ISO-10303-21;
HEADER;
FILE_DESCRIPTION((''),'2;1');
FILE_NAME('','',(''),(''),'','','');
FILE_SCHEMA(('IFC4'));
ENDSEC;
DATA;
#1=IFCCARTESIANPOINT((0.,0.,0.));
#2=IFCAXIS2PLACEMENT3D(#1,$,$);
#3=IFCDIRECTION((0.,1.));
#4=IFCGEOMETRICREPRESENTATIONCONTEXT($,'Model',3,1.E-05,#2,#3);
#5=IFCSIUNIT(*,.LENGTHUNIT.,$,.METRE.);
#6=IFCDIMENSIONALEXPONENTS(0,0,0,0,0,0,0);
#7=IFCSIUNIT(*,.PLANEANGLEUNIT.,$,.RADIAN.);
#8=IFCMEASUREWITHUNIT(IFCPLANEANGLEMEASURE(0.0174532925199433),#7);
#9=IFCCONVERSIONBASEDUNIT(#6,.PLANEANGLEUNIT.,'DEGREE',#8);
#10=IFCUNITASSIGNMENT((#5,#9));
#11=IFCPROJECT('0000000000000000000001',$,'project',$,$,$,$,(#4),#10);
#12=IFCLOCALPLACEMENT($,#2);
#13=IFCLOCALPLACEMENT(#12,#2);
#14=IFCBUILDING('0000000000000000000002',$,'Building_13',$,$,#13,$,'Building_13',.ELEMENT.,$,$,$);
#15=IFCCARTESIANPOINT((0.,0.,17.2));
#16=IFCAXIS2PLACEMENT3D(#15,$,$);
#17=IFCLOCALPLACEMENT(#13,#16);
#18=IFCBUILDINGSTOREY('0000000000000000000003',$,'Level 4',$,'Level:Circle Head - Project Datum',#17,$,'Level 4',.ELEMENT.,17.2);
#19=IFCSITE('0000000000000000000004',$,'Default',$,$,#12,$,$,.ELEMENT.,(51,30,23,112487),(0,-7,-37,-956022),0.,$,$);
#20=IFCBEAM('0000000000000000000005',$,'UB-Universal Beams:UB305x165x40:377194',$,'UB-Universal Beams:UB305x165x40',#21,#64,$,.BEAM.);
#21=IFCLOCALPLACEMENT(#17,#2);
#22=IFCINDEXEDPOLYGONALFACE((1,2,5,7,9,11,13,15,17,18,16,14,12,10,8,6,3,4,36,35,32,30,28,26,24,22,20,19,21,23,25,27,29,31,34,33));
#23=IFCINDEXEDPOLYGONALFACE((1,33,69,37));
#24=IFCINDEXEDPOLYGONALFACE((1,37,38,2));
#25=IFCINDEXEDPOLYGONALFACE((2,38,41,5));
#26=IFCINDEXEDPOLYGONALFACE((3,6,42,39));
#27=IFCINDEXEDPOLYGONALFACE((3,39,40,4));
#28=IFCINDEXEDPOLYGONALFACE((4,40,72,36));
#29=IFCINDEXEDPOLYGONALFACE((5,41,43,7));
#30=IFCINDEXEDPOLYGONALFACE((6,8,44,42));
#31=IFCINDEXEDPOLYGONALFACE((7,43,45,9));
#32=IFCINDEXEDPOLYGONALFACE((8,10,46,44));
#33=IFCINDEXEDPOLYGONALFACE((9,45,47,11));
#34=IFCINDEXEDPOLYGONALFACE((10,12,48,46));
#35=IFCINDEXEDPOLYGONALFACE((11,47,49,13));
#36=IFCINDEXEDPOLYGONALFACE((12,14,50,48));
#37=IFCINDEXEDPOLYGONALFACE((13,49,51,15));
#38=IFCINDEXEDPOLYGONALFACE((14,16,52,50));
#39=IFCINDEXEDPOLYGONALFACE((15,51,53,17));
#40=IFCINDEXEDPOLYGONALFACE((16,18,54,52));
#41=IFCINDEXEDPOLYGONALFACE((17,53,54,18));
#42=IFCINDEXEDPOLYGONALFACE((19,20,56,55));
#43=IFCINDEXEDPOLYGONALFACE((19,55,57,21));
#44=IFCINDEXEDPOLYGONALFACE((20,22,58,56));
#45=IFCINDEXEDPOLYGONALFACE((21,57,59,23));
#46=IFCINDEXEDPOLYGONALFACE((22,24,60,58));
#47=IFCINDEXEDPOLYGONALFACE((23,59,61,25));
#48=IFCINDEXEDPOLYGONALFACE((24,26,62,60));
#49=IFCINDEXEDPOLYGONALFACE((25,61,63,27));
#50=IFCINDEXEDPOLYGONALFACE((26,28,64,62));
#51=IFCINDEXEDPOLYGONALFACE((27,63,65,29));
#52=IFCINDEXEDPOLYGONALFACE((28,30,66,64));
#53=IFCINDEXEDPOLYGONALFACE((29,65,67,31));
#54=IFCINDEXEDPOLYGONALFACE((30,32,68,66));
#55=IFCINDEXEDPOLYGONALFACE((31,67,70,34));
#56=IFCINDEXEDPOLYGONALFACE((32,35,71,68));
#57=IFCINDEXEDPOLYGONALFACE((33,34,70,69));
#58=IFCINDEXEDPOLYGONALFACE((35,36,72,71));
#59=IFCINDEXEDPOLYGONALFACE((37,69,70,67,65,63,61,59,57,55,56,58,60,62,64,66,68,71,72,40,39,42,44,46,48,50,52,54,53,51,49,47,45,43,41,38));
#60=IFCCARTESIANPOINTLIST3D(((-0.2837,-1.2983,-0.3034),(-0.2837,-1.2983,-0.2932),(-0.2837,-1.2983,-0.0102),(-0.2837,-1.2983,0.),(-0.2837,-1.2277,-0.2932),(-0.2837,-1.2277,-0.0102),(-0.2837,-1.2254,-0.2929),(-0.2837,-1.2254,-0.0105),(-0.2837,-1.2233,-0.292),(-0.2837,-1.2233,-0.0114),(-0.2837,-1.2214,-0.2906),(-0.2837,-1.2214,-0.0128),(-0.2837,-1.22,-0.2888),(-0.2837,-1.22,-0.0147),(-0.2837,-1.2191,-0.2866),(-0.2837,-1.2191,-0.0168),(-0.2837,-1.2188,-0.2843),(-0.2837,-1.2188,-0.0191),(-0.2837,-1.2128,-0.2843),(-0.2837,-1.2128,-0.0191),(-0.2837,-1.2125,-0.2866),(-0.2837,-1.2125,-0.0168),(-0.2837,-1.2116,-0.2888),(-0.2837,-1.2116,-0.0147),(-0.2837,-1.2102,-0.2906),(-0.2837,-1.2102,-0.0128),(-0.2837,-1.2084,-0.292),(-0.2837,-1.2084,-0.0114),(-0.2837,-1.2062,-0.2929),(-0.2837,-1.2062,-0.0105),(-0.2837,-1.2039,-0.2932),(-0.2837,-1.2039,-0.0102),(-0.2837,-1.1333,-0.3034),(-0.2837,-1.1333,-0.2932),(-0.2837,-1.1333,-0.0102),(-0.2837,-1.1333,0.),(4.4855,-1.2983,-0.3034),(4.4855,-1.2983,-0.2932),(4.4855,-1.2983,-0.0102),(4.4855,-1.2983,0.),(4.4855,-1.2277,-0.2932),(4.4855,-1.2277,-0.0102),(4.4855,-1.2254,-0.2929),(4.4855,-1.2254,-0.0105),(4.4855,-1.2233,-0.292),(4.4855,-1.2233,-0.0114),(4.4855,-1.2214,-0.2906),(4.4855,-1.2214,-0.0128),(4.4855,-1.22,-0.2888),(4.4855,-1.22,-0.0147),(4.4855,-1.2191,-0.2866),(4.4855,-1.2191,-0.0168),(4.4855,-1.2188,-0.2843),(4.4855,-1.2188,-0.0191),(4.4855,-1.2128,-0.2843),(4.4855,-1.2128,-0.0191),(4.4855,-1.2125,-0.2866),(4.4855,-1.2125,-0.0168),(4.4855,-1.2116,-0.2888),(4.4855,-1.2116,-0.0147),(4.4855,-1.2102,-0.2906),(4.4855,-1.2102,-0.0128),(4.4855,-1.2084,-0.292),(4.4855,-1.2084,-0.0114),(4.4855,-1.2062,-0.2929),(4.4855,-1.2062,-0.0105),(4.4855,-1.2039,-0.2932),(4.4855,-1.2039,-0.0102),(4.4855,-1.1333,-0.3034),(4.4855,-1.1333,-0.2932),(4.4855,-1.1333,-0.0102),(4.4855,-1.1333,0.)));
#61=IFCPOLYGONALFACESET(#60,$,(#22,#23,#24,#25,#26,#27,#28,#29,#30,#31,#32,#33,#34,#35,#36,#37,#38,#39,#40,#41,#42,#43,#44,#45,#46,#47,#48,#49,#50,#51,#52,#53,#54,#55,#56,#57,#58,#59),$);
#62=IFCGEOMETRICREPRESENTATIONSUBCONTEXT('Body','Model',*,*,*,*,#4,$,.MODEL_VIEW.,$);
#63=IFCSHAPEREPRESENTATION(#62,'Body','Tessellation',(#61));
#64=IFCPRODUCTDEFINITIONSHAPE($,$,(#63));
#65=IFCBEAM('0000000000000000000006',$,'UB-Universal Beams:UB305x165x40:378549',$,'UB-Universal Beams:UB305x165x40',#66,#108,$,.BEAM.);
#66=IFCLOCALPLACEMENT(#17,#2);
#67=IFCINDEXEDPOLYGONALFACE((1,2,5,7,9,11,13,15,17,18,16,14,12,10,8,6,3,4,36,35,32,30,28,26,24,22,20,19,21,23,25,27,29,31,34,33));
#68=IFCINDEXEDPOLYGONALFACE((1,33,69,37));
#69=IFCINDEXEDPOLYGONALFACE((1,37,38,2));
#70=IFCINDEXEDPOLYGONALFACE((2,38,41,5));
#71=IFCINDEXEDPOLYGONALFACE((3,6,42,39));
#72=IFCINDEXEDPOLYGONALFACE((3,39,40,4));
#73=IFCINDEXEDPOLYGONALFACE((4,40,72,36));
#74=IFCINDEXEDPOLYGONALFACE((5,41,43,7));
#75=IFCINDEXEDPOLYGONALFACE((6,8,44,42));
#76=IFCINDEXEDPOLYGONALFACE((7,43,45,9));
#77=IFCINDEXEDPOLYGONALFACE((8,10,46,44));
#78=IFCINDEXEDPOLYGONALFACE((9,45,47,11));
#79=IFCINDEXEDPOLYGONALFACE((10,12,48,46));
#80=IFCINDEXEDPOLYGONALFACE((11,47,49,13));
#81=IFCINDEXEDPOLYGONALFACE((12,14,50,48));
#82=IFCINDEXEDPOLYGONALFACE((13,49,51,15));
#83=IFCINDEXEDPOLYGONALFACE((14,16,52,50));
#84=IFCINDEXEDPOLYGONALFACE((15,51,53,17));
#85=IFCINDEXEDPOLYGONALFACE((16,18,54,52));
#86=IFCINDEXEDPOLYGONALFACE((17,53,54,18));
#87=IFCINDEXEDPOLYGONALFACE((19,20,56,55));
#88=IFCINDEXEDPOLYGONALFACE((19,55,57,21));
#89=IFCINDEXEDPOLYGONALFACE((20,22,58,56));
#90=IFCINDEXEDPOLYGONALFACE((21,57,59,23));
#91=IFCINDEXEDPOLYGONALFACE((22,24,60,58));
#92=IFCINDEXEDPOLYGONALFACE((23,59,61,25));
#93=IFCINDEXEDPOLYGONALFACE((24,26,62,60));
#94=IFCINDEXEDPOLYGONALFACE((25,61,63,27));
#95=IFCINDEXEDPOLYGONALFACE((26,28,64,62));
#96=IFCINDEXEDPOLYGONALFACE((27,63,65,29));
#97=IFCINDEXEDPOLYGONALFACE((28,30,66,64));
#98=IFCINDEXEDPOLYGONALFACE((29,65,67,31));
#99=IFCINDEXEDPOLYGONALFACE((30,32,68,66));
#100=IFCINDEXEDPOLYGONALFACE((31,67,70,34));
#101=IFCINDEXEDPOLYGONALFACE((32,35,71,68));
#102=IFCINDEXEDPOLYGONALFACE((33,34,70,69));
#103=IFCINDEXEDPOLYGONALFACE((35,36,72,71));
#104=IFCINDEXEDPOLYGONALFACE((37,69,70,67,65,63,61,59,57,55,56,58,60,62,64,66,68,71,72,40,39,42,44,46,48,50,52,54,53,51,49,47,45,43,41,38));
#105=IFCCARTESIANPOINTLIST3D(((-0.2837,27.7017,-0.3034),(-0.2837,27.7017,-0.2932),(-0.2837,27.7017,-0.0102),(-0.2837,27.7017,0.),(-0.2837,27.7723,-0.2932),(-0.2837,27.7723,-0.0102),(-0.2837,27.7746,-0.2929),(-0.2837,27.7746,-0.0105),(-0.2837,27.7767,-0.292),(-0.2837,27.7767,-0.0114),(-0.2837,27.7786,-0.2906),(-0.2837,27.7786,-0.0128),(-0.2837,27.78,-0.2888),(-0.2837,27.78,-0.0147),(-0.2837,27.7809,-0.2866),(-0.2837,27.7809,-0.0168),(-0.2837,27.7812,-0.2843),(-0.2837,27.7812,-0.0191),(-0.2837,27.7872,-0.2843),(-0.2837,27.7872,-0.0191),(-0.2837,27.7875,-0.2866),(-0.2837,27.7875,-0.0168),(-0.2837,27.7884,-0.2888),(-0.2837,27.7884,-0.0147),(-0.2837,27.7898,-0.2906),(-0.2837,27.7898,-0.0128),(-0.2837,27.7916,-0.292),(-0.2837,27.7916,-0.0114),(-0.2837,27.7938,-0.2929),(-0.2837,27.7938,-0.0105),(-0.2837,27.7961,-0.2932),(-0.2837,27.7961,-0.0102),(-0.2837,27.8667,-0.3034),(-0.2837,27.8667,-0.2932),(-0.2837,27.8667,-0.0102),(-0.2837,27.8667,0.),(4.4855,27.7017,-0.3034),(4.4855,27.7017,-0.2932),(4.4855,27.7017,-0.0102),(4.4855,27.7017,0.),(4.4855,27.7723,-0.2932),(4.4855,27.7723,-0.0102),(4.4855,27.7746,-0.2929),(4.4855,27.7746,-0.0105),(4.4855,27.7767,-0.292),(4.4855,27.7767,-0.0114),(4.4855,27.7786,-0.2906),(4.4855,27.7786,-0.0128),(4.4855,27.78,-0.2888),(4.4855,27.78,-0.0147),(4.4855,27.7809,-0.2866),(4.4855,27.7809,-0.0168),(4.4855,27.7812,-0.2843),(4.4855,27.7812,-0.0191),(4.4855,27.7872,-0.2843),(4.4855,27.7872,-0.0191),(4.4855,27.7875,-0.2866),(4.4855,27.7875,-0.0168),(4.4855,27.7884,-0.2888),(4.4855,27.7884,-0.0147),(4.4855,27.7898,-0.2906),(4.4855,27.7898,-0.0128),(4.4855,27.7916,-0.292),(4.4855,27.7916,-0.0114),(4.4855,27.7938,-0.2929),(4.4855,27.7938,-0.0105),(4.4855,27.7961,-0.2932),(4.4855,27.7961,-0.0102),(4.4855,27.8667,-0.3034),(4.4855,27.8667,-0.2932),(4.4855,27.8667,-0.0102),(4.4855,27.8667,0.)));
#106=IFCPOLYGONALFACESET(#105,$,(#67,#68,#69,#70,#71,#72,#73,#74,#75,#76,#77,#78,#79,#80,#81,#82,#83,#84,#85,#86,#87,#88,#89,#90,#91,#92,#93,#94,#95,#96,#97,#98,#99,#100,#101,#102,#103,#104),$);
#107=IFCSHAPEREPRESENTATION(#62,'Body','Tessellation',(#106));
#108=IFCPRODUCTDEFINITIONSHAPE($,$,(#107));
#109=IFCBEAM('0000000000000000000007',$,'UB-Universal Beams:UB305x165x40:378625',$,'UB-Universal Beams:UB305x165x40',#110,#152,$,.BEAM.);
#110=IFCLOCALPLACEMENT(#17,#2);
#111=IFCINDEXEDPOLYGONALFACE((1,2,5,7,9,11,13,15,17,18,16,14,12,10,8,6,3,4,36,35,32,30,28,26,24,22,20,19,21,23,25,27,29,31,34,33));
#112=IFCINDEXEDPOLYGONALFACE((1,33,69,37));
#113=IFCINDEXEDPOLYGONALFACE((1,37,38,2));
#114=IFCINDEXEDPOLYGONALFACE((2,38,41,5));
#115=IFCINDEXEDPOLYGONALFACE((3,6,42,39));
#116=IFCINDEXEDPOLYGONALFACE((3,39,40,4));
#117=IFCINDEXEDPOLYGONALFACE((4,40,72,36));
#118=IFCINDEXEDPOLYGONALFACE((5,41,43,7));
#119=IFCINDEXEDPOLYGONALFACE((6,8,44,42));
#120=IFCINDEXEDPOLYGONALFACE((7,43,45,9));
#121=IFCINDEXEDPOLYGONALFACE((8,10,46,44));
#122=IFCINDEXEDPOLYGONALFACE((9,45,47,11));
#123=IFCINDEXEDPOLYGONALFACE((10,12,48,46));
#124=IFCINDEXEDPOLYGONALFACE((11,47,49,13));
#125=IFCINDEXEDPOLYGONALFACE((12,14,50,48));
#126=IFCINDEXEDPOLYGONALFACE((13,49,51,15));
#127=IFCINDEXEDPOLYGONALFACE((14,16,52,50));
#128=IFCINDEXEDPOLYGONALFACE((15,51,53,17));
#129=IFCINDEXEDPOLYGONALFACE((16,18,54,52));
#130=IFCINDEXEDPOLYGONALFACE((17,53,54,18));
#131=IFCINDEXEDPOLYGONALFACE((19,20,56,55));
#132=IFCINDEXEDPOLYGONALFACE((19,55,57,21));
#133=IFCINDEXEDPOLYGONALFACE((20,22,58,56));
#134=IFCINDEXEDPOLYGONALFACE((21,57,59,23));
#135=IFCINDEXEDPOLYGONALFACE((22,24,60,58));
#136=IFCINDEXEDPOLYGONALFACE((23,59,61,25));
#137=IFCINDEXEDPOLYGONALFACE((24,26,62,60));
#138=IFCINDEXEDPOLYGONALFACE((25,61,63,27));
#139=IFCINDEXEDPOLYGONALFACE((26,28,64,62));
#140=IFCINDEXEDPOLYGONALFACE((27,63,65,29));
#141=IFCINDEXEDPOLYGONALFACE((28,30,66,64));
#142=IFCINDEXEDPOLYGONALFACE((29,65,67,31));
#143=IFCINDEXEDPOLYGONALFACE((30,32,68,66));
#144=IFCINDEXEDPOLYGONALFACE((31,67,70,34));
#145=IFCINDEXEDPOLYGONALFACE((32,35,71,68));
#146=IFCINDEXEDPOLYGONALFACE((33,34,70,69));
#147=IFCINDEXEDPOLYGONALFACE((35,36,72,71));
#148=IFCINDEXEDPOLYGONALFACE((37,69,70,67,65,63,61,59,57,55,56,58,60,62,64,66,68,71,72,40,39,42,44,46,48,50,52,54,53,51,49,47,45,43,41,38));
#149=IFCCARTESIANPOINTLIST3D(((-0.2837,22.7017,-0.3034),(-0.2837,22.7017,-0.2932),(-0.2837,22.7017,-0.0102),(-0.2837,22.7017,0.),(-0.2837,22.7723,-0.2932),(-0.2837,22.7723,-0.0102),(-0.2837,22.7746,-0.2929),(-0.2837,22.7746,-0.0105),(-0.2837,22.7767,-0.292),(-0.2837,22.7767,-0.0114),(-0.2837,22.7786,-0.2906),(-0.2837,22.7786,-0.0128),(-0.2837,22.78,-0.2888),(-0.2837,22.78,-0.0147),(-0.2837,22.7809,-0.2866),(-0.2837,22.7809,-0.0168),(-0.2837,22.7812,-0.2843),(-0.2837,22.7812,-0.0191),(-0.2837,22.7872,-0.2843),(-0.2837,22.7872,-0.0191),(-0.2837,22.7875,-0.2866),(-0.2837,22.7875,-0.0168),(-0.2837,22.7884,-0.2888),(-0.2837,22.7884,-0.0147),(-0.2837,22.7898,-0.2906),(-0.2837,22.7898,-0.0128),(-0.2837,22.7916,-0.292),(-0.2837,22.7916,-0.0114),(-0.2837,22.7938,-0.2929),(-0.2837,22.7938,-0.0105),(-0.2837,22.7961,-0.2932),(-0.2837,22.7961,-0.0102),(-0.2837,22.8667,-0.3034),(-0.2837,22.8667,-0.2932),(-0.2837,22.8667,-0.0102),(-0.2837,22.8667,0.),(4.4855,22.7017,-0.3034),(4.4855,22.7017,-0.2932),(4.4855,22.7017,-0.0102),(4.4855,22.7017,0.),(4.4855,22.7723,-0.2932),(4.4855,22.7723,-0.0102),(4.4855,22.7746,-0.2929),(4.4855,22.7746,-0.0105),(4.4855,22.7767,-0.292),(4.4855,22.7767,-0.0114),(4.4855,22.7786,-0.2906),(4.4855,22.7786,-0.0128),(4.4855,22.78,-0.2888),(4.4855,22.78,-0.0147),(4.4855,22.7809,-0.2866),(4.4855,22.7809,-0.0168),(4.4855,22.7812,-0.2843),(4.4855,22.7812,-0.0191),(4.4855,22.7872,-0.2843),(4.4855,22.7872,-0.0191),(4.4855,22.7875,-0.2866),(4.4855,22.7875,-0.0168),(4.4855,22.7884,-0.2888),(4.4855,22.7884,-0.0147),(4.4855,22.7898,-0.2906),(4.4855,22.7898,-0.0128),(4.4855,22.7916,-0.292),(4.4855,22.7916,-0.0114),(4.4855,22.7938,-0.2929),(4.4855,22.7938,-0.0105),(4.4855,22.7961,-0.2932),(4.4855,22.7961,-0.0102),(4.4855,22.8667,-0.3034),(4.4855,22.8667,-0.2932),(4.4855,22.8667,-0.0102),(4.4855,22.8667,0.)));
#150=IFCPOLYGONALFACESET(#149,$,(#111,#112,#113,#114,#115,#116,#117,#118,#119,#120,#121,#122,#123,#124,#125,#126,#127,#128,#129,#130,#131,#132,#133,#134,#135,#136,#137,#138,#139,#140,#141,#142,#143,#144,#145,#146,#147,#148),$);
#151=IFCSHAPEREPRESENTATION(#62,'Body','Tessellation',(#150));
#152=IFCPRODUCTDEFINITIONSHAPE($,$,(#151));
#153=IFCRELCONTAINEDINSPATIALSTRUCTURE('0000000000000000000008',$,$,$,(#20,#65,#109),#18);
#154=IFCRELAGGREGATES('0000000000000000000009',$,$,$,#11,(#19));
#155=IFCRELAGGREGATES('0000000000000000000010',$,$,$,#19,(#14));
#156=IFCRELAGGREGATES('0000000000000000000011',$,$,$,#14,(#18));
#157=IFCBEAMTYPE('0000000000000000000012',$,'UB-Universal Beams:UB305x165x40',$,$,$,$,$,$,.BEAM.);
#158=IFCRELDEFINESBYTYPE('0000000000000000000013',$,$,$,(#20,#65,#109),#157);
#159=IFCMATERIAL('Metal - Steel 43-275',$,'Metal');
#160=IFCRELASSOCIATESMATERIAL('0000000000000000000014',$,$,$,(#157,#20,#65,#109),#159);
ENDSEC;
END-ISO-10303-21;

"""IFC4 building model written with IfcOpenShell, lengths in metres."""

from ifc_helpers import new_model, entity, si_unit, converted_unit, direction, frame, origin, place, context, subcontext, project, spatial, line, arc, indexed_curve, outline, extrude, source, transform, mapped, material, type_object, type_shapes, element, save


model = new_model("IFC4")

# Units and contexts
model_context = context("Model", 3, precision=1e-05, world=origin(), true_north=direction((0.0, 1.0)))
body_context = subcontext(model_context, "Body", "Model", "MODEL_VIEW")
ifc_project = project(units=[si_unit("LENGTHUNIT", "METRE"), converted_unit("PLANEANGLEUNIT", "DEGREE", entity("IfcPlaneAngleMeasure", 0.0174532925199433), si_unit("PLANEANGLEUNIT", "RADIAN"), dimensions=[0, 0, 0, 0, 0, 0, 0])], contexts=[model_context])

# Site, building, storey
site_placement = place(None, origin())
site = spatial("IfcSite", under=ifc_project, at=site_placement, Name="Default", CompositionType="ELEMENT", RefLatitude=(51, 30, 23, 112487), RefLongitude=(0, -7, -37, -956022), RefElevation=0.0)
building_placement = place(site_placement, origin())
building = spatial("IfcBuilding", under=site, at=building_placement, Name="Building_13", LongName="Building_13", CompositionType="ELEMENT")
storey_placement = place(building_placement, frame((0.0, 0.0, 17.2)))
storey = spatial("IfcBuildingStorey", under=building, at=storey_placement, Name="Level 4", ObjectType="Level:Circle Head - Project Datum", LongName="Level 4", CompositionType="ELEMENT", Elevation=17.2)

# Beams
ifc_material_1 = material(Name="Metal - Steel 43-275", Category="Metal")
beam_type_1 = type_object("IfcBeamType", Name="UB-Universal Beams:UB305x165x40", PredefinedType="BEAM", material=ifc_material_1)
shared_shape_1 = source(origin(), body_context, "Body", "SweptSolid", [
    extrude(outline(indexed_curve([(-0.0825, -0.1415), (-0.0825, -0.1517), (0.0825, -0.1517), (0.0825, -0.1415), (0.0119, -0.1415), (0.0056, -0.1389), (0.003, -0.1326), (0.003, 0.1326), (0.0056, 0.1389), (0.0119, 0.1415), (0.0825, 0.1415), (0.0825, 0.1517), (-0.0825, 0.1517), (-0.0825, 0.1415), (-0.0119, 0.1415), (-0.0056, 0.1389), (-0.003, 0.1326), (-0.003, -0.1326), (-0.0056, -0.1389), (-0.0119, -0.1415)], segments=[line(1, 2, 3, 4, 5), arc(5, 6, 7), line(7, 8), arc(8, 9, 10), line(10, 11, 12, 13, 14, 15), arc(15, 16, 17), line(17, 18), arc(18, 19, 20), line(20, 1)], self_intersect=False)), frame((-2.3846, 0.0, 0.0), z_axis=(-1.0, 0.0, 0.0), x_axis=(0.0, -1.0, 0.0)), (0.0, 0.0, -1.0), 4.7692),
])
type_shapes(beam_type_1, [shared_shape_1])
beam_1_placement = place(storey_placement, frame((2.1009, -1.2158, -0.1517), z_axis=(0.0, 0.0, 1.0), x_axis=(-1.0, 0.0, 0.0)))
element("IfcBeam", 1, at=beam_1_placement, inside=storey, type_object=beam_type_1, material=ifc_material_1, Name="UB-Universal Beams:UB305x165x40:377194", ObjectType="UB-Universal Beams:UB305x165x40", PredefinedType="BEAM", context=body_context, shape_type="MappedRepresentation", body=[
    mapped(shared_shape_1, transform((0.0, 0.0, 0.0), scale=1.0)),
])
beam_2_placement = place(storey_placement, frame((2.1009, 27.7842, -0.1517)))
element("IfcBeam", 2, at=beam_2_placement, inside=storey, type_object=beam_type_1, material=ifc_material_1, Name="UB-Universal Beams:UB305x165x40:378549", ObjectType="UB-Universal Beams:UB305x165x40", PredefinedType="BEAM", context=body_context, shape_type="MappedRepresentation", body=[
    mapped(shared_shape_1, transform((0.0, 0.0, 0.0), scale=1.0)),
])
beam_3_placement = place(storey_placement, frame((2.1009, 22.7842, -0.1517), z_axis=(0.0, 0.0, 1.0), x_axis=(-1.0, 0.0, 0.0)))
element("IfcBeam", 3, at=beam_3_placement, inside=storey, type_object=beam_type_1, material=ifc_material_1, Name="UB-Universal Beams:UB305x165x40:378625", ObjectType="UB-Universal Beams:UB305x165x40", PredefinedType="BEAM", context=body_context, shape_type="MappedRepresentation", body=[
    mapped(shared_shape_1, transform((0.0, 0.0, 0.0), scale=1.0)),
])

save(model, "model.ifc")
